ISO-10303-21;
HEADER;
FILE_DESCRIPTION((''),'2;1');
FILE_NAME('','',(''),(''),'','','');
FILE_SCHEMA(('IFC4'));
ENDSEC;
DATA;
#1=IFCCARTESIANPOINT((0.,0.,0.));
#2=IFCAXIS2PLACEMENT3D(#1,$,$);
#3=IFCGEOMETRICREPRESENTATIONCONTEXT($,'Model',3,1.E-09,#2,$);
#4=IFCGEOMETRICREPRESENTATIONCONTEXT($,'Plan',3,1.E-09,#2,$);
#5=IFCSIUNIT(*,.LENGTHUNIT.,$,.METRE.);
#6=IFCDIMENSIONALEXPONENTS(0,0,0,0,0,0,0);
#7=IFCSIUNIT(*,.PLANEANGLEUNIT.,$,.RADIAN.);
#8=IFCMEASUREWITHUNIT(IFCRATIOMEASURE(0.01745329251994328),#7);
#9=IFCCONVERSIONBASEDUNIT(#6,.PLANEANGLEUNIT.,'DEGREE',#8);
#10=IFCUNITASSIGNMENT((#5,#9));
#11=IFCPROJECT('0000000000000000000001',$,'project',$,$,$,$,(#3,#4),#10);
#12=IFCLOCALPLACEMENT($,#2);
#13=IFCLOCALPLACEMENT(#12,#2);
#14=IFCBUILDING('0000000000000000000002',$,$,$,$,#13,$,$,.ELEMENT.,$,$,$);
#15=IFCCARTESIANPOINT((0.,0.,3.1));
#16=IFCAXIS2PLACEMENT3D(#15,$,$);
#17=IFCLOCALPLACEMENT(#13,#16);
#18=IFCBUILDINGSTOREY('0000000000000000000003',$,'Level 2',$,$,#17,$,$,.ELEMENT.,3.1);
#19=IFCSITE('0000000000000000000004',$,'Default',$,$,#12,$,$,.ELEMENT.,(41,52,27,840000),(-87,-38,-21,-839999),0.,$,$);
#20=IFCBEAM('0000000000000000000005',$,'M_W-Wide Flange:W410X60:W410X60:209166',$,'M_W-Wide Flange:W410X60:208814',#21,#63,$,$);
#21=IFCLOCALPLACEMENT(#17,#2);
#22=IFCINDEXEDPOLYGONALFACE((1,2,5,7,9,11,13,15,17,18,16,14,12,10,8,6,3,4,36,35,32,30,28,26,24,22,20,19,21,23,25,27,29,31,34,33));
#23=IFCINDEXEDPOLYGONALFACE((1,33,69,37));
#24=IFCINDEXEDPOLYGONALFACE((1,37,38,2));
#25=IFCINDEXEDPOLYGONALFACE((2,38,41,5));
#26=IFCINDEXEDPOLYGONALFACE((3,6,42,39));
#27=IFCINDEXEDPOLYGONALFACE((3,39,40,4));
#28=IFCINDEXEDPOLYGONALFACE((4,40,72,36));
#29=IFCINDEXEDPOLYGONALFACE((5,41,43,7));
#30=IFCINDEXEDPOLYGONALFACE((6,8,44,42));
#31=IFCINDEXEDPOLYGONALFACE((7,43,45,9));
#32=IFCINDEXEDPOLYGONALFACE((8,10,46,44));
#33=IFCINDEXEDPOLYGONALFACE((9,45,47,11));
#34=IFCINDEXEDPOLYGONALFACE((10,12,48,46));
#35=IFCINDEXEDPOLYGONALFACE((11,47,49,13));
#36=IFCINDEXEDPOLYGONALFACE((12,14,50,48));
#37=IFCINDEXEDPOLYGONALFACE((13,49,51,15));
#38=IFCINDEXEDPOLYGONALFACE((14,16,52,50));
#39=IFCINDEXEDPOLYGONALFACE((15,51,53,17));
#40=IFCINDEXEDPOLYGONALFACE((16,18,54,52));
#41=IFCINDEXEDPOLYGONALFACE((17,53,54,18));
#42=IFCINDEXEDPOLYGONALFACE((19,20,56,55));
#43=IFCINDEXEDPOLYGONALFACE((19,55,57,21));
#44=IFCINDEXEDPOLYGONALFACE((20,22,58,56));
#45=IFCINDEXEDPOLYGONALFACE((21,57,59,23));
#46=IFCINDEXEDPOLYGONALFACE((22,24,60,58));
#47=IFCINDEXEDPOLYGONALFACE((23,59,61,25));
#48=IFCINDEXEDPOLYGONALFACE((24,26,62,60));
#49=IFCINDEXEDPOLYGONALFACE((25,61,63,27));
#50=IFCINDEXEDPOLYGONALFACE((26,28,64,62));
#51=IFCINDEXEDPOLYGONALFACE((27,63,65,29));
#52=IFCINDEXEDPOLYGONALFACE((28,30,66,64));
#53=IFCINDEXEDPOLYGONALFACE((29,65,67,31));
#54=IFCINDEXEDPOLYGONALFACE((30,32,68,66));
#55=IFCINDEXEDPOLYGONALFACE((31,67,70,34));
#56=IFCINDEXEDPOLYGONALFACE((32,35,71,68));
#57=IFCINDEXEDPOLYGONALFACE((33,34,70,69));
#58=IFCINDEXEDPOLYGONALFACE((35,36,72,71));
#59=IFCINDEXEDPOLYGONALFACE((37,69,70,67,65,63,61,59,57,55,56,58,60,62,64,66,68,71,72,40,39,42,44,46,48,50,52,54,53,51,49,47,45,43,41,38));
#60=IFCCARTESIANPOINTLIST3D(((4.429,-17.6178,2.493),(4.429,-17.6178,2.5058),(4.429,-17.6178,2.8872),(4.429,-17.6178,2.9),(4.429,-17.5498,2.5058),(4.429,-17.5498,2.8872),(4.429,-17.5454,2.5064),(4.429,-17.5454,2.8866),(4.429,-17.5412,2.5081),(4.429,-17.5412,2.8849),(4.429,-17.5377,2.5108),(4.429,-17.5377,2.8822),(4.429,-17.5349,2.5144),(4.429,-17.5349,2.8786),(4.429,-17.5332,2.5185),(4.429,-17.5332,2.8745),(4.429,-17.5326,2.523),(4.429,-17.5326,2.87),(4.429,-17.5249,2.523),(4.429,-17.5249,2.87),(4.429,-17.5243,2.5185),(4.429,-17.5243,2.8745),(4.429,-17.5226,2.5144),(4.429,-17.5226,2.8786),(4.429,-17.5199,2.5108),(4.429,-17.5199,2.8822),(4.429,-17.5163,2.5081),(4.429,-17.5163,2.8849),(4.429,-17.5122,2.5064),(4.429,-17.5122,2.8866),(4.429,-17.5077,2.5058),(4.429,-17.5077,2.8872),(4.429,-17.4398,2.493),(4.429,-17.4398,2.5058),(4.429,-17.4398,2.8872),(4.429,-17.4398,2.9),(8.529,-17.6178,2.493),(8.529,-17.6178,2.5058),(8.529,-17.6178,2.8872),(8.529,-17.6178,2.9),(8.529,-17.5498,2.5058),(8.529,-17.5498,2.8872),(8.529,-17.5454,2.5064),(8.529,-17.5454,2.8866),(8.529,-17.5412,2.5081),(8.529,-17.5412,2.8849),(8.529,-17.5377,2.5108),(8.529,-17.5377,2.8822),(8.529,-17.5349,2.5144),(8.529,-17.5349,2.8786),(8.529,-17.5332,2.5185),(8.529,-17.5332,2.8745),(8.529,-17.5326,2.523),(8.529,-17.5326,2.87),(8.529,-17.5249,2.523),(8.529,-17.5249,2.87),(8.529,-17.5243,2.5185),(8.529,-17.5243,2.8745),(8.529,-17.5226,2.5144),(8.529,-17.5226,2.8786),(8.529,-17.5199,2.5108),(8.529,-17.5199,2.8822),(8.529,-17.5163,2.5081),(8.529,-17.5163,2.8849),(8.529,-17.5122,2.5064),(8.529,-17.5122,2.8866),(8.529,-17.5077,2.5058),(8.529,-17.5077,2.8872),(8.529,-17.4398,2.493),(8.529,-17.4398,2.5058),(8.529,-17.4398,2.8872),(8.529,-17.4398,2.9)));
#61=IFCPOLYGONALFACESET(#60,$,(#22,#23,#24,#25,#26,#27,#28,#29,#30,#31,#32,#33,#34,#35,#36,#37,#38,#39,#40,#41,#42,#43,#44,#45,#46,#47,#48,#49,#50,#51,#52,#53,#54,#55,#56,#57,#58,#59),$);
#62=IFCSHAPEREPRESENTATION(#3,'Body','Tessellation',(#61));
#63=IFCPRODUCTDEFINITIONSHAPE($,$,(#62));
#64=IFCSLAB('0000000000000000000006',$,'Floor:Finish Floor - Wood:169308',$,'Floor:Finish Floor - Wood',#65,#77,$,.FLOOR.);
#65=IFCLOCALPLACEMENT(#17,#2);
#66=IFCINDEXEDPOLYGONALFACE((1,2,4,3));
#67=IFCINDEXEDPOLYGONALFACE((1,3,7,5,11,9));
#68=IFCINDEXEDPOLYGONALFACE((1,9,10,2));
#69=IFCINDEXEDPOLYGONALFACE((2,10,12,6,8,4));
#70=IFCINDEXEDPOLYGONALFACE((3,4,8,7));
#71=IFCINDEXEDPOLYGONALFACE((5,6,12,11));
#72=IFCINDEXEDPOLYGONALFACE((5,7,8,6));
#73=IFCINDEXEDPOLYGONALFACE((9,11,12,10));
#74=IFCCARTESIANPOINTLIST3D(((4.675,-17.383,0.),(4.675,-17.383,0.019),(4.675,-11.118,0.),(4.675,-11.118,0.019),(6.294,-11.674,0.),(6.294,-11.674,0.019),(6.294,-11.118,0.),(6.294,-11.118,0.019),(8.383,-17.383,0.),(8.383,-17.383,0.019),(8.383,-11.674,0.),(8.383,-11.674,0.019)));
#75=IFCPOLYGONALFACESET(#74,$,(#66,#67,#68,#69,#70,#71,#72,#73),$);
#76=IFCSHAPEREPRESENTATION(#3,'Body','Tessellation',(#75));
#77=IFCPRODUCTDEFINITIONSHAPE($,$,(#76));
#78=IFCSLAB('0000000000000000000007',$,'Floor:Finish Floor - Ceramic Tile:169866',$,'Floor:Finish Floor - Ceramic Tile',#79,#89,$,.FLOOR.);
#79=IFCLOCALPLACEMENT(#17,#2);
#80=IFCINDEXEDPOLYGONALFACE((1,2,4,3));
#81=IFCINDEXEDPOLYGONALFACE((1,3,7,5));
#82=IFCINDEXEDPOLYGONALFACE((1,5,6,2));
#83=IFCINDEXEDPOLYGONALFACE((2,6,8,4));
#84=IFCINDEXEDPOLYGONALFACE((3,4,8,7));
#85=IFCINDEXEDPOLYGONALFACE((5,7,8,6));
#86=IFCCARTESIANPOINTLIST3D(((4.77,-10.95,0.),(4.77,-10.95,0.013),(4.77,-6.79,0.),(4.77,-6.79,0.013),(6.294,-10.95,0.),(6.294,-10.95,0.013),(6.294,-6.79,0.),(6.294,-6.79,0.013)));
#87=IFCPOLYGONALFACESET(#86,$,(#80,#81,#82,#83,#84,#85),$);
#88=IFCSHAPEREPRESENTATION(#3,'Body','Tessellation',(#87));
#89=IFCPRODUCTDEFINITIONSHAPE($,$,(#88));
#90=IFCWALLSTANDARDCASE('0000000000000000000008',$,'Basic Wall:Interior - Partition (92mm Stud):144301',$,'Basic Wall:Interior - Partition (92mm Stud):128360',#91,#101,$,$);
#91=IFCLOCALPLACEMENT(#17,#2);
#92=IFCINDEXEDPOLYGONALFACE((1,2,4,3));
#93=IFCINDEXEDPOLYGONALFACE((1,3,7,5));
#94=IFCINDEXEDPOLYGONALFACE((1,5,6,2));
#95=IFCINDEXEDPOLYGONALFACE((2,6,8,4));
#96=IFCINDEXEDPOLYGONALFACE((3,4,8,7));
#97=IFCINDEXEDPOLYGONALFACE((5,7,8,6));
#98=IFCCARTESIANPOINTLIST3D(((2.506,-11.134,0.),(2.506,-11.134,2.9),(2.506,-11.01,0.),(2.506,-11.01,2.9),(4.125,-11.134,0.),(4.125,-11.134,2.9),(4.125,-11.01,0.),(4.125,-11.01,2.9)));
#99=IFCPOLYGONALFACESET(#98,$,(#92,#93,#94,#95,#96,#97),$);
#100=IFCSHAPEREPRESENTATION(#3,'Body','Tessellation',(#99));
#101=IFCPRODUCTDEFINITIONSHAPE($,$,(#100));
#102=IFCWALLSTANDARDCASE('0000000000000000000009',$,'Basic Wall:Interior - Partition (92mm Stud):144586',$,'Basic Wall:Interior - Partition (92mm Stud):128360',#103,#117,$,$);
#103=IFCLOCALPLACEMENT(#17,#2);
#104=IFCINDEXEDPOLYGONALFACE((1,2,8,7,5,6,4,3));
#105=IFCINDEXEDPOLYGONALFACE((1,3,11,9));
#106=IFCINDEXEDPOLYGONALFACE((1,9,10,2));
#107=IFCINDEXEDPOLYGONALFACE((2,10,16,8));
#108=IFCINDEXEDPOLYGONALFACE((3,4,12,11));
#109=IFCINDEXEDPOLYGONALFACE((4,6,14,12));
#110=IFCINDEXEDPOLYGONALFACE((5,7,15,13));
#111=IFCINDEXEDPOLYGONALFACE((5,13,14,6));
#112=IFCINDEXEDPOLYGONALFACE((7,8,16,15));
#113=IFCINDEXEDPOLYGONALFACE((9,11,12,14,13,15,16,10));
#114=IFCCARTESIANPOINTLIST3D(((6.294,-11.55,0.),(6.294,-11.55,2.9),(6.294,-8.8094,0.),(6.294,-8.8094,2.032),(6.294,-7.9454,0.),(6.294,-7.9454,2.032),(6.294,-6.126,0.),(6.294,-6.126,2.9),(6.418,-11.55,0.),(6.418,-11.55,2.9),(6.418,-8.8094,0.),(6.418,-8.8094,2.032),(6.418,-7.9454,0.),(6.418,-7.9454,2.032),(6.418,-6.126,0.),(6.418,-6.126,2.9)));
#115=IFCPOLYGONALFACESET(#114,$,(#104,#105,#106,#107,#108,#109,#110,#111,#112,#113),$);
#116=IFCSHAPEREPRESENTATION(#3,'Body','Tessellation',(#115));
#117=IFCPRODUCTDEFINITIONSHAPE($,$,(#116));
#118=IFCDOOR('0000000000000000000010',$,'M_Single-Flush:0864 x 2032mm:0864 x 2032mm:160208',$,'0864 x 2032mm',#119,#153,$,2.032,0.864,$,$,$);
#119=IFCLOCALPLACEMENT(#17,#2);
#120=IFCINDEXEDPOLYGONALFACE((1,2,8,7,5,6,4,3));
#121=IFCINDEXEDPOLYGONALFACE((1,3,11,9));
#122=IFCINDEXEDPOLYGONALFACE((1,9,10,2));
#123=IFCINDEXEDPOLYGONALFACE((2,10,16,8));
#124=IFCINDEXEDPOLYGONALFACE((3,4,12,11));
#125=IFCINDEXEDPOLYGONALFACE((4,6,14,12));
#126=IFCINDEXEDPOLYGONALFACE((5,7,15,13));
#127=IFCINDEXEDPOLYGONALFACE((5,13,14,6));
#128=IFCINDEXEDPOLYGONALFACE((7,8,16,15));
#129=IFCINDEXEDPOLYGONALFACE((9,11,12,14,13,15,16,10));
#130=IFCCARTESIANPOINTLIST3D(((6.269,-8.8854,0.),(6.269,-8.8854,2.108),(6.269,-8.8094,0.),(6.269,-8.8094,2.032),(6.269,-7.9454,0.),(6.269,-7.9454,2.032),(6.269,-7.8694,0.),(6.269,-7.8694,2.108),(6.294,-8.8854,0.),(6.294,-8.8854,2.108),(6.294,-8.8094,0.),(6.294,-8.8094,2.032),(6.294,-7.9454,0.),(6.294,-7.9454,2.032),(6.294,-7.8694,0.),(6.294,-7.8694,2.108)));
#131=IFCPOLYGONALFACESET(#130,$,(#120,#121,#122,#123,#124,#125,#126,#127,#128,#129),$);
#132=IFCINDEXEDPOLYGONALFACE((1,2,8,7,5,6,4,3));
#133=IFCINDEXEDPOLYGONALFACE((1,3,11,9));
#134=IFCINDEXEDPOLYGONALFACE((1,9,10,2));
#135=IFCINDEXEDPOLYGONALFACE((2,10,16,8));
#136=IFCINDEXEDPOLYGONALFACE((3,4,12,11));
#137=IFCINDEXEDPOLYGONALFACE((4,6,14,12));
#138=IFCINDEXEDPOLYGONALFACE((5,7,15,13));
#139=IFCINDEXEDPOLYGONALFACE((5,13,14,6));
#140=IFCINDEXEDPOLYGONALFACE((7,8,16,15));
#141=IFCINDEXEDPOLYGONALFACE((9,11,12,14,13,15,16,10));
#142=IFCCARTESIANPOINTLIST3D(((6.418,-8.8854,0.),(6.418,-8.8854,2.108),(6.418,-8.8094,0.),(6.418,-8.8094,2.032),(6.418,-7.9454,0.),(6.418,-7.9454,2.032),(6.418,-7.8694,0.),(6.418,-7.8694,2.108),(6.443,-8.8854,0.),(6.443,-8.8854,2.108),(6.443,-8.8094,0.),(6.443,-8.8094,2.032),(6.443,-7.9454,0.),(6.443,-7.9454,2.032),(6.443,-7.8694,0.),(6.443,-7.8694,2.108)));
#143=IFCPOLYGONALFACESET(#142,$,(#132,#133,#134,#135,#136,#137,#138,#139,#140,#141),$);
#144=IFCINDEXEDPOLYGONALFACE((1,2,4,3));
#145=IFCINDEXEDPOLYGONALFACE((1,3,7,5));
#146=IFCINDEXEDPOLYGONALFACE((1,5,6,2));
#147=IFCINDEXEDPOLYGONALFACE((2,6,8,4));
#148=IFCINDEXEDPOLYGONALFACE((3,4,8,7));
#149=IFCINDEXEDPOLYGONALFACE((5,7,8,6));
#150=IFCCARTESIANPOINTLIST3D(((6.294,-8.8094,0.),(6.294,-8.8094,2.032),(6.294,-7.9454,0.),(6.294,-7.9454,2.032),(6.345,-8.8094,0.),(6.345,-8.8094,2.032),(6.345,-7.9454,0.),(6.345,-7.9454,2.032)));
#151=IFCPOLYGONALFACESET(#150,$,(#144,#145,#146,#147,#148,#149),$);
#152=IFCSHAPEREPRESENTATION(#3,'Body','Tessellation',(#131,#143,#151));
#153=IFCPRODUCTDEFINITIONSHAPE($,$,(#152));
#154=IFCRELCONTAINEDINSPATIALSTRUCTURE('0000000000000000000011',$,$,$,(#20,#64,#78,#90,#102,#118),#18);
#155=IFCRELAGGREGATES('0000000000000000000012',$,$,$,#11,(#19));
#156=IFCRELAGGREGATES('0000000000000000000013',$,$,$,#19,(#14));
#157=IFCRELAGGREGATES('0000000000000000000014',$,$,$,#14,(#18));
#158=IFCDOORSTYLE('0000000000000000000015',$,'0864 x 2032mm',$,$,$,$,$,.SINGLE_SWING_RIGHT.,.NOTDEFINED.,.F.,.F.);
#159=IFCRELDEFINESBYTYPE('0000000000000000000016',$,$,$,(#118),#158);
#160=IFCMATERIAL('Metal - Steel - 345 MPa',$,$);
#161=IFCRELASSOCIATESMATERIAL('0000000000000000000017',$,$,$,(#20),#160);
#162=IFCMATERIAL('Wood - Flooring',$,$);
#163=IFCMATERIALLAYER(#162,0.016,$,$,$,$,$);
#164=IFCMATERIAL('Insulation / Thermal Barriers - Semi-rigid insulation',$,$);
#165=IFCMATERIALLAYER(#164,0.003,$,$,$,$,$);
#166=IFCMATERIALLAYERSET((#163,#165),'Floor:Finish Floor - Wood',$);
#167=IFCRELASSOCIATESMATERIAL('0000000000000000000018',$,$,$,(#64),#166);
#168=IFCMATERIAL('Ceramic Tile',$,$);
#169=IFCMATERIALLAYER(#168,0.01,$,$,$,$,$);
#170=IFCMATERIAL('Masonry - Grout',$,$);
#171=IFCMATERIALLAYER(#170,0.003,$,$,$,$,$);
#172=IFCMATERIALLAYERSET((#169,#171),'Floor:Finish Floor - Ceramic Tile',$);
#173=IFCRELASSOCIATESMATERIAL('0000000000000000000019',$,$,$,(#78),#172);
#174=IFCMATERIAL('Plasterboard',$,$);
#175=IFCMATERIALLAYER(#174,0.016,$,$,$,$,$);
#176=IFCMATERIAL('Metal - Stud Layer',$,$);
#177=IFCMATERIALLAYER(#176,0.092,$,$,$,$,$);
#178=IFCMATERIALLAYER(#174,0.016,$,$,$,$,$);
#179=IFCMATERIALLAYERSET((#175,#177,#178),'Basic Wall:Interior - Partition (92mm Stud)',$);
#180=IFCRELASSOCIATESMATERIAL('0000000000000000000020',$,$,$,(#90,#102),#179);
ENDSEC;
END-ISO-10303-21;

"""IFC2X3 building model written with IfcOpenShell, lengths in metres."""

from ifc_helpers import new_model, entity, si_unit, converted_unit, frame, frame_2d, origin, origin_2d_with_axis, place, context, project, spatial, polyline, circle_curve, parameter, trimmed, segment, composite_curve, rectangle, outline, extrude, source, transform, mapped, material, layer, layer_set, layer_usage, type_object, type_shapes, element, fill, save


model = new_model("IFC2X3")

# Units and contexts
model_context = context("Model", 3, precision=1e-09, world=origin())
plan_context = context("Plan", 3, precision=1e-09, world=origin())
ifc_project = project(units=[si_unit("LENGTHUNIT", "METRE"), converted_unit("PLANEANGLEUNIT", "DEGREE", entity("IfcRatioMeasure", 0.01745329251994328), si_unit("PLANEANGLEUNIT", "RADIAN"), dimensions=[0, 0, 0, 0, 0, 0, 0])], contexts=[model_context, plan_context])

# Site, building, storey
site_placement = place(None, origin())
site = spatial("IfcSite", under=ifc_project, at=site_placement, Name="Default", CompositionType="ELEMENT", RefLatitude=(41, 52, 27, 840000), RefLongitude=(-87, -38, -21, -839999), RefElevation=0.0)
building_placement = place(site_placement, origin())
building = spatial("IfcBuilding", under=site, at=building_placement, CompositionType="ELEMENT")
storey_placement = place(building_placement, frame((0.0, 0.0, 3.1)))
storey = spatial("IfcBuildingStorey", under=building, at=storey_placement, Name="Level 2", CompositionType="ELEMENT", Elevation=3.1)

# Beam
ifc_material_1 = material(Name="Metal - Steel - 345 MPa")
beam_placement = place(storey_placement, frame((4.429, -17.5288, 2.9), z_axis=(0.0, 0.0, 1.0), x_axis=(0.0, -1.0, 0.0)))
element("IfcBeam", 1, at=beam_placement, inside=storey, material=ifc_material_1, Name="M_W-Wide Flange:W410X60:W410X60:209166", ObjectType="M_W-Wide Flange:W410X60:208814", context=model_context, shape_type="SweptSolid", body=[
    extrude(outline(composite_curve([segment(polyline([(-0.089, -0.1907), (-0.089, -0.2035)]), True, "CONTINUOUS"), segment(polyline([(-0.089, -0.2035), (0.089, -0.2035)]), True, "CONTINUOUS"), segment(polyline([(0.089, -0.2035), (0.089, -0.1907)]), True, "CONTINUOUS"), segment(polyline([(0.089, -0.1907), (0.021, -0.1907)]), True, "CONTINUOUS"), segment(trimmed(circle_curve(frame_2d((0.021, -0.1735), x_axis=(0.0, -1.0)), 0.0172), [parameter(270.0)], [parameter(360.0)], True, "PARAMETER"), False, "CONTINUOUS"), segment(polyline([(0.0038, -0.1735), (0.0038, 0.1735)]), True, "CONTINUOUS"), segment(trimmed(circle_curve(frame_2d((0.021, 0.1735), x_axis=(-1.0, 0.0)), 0.0172), [parameter(270.0)], [parameter(360.0)], True, "PARAMETER"), False, "CONTINUOUS"), segment(polyline([(0.021, 0.1907), (0.089, 0.1907)]), True, "CONTINUOUS"), segment(polyline([(0.089, 0.1907), (0.089, 0.2035)]), True, "CONTINUOUS"), segment(polyline([(0.089, 0.2035), (-0.089, 0.2035)]), True, "CONTINUOUS"), segment(polyline([(-0.089, 0.2035), (-0.089, 0.1907)]), True, "CONTINUOUS"), segment(polyline([(-0.089, 0.1907), (-0.0211, 0.1907)]), True, "CONTINUOUS"), segment(trimmed(circle_curve(frame_2d((-0.0211, 0.1735), x_axis=(0.0, 1.0)), 0.0172), [parameter(270.0)], [parameter(0.0)], True, "PARAMETER"), False, "CONTINUOUS"), segment(polyline([(-0.0039, 0.1735), (-0.0039, -0.1735)]), True, "CONTINUOUS"), segment(trimmed(circle_curve(frame_2d((-0.0211, -0.1735), x_axis=(1.0, 0.0)), 0.0172), [parameter(270.0)], [parameter(0.0)], True, "PARAMETER"), False, "CONTINUOUS"), segment(polyline([(-0.0211, -0.1907), (-0.089, -0.1907)]), True, "CONTINUOUS")], self_intersect=False)), frame((0.0, 0.0, -0.2035), z_axis=(0.0, -1.0, 0.0), x_axis=(1.0, 0.0, 0.0)), (0.0, 0.0, -1.0), 4.1),
])

# Slabs
ifc_material_2 = material(Name="Wood - Flooring")
ifc_layer_1 = layer(ifc_material_2, 0.016)
ifc_material_3 = material(Name="Insulation / Thermal Barriers - Semi-rigid insulation")
ifc_layer_2 = layer(ifc_material_3, 0.003)
ifc_layer_set_1 = layer_set([ifc_layer_1, ifc_layer_2], Name="Floor:Finish Floor - Wood")
ifc_layer_usage_1 = layer_usage(ifc_layer_set_1, "AXIS3", "POSITIVE", 0.0)
slab_1_placement = place(storey_placement, frame((4.675, -17.383, 0.0)))
element("IfcSlab", 2, at=slab_1_placement, inside=storey, material=ifc_layer_usage_1, Name="Floor:Finish Floor - Wood:169308", ObjectType="Floor:Finish Floor - Wood", PredefinedType="FLOOR", context=model_context, shape_type="SweptSolid", body=[
    extrude(outline(polyline([(-1.854, 2.5765), (-1.854, -3.1325), (1.854, -3.1325), (1.854, 3.1325), (0.235, 3.1325), (0.235, 2.5765), (-1.854, 2.5765)])), frame((1.854, 3.1325, 0.019), z_axis=(0.0, 0.0, -1.0), x_axis=(-1.0, 0.0, 0.0)), (0.0, 0.0, 1.0), 0.019),
])
ifc_material_4 = material(Name="Ceramic Tile")
ifc_layer_3 = layer(ifc_material_4, 0.01)
ifc_material_5 = material(Name="Masonry - Grout")
ifc_layer_4 = layer(ifc_material_5, 0.003)
ifc_layer_set_2 = layer_set([ifc_layer_3, ifc_layer_4], Name="Floor:Finish Floor - Ceramic Tile")
ifc_layer_usage_2 = layer_usage(ifc_layer_set_2, "AXIS3", "POSITIVE", 0.0)
slab_2_placement = place(storey_placement, frame((4.77, -10.95, 0.0)))
element("IfcSlab", 3, at=slab_2_placement, inside=storey, material=ifc_layer_usage_2, Name="Floor:Finish Floor - Ceramic Tile:169866", ObjectType="Floor:Finish Floor - Ceramic Tile", PredefinedType="FLOOR", context=model_context, shape_type="SweptSolid", body=[
    extrude(rectangle(XDim=4.16, YDim=1.524, at=frame_2d((0.0, 0.0), x_axis=(0.0, -1.0))), frame((0.762, 2.08, 0.013), z_axis=(0.0, 0.0, -1.0), x_axis=(-1.0, 0.0, 0.0)), (0.0, 0.0, 1.0), 0.013),
])

# Shared definitions
ifc_material_6 = material(Name="Metal - Stud Layer")
ifc_material_7 = material(Name="Plasterboard")

# Wall
ifc_layer_5 = layer(ifc_material_7, 0.016)
ifc_layer_6 = layer(ifc_material_6, 0.092)
ifc_layer_7 = layer(ifc_material_7, 0.016)
ifc_layer_set_3 = layer_set([ifc_layer_5, ifc_layer_6, ifc_layer_7], Name="Basic Wall:Interior - Partition (92mm Stud)")
ifc_layer_usage_3 = layer_usage(ifc_layer_set_3, "AXIS2", "NEGATIVE", 0.062)
wall_1_placement = place(storey_placement, frame((4.125, -11.072, 0.0), z_axis=(0.0, 0.0, 1.0), x_axis=(-1.0, 0.0, 0.0)))
element("IfcWallStandardCase", 4, at=wall_1_placement, inside=storey, material=ifc_layer_usage_3, Name="Basic Wall:Interior - Partition (92mm Stud):144301", ObjectType="Basic Wall:Interior - Partition (92mm Stud):128360", context=model_context, shape_type="SweptSolid", body=[
    extrude(rectangle(XDim=1.619, YDim=0.124, at=frame_2d((0.8095, 0.0), x_axis=(-1.0, 0.0))), origin(), (0.0, 0.0, 1.0), 2.9),
])

# Wall, opening, door
ifc_layer_usage_4 = layer_usage(ifc_layer_set_3, "AXIS2", "NEGATIVE", 0.062)
wall_2_placement = place(storey_placement, frame((6.356, -11.55, 0.0), z_axis=(0.0, 0.0, 1.0), x_axis=(0.0, 1.0, 0.0)))
wall_2 = element("IfcWallStandardCase", 5, at=wall_2_placement, inside=storey, material=ifc_layer_usage_4, Name="Basic Wall:Interior - Partition (92mm Stud):144586", ObjectType="Basic Wall:Interior - Partition (92mm Stud):128360", context=model_context, shape_type="SweptSolid", body=[
    extrude(rectangle(XDim=5.424, YDim=0.124, at=frame_2d((2.712, 0.0), x_axis=(-1.0, 0.0))), origin(), (0.0, 0.0, 1.0), 2.9),
])
opening_1_placement = place(wall_2_placement, frame((2.7406, -0.062, 0.0)))
opening_1 = element("IfcOpeningElement", 6, at=opening_1_placement, cuts=wall_2, ObjectType="Opening", context=model_context, shape_type="SweptSolid", body=[
    extrude(rectangle(XDim=0.864, YDim=2.032, at=frame_2d((1.016, 0.432), x_axis=(0.0, 1.0))), frame((0.0, 0.0, 0.0), z_axis=(0.0, 1.0, 0.0), x_axis=(0.0, 0.0, 1.0)), (0.0, 0.0, 1.0), 0.124),
])
door_style = type_object("IfcDoorStyle", Name="0864 x 2032mm", ConstructionType="NOTDEFINED", OperationType="SINGLE_SWING_RIGHT", ParameterTakesPrecedence=False, Sizeable=False)
shared_shape_1 = source(origin(), model_context, "Body", "SweptSolid", [
    extrude(outline(polyline([(-0.508, -1.073), (0.508, -1.073), (0.508, 1.035), (0.432, 1.035), (0.432, -0.997), (-0.432, -0.997), (-0.432, 1.035), (-0.508, 1.035), (-0.508, -1.073)])), frame((0.432, 0.124, 1.035), z_axis=(0.0, 1.0, 0.0), x_axis=(1.0, 0.0, 0.0)), (0.0, 0.0, 1.0), 0.025),
    extrude(outline(polyline([(-1.073, -0.508), (1.035, -0.508), (1.035, -0.432), (-0.997, -0.432), (-0.997, 0.432), (1.035, 0.432), (1.035, 0.508), (-1.073, 0.508), (-1.073, -0.508)])), frame((0.432, -0.025, 1.035), z_axis=(0.0, 1.0, 0.0), x_axis=(0.0, 0.0, -1.0)), (0.0, 0.0, 1.0), 0.025),
    extrude(rectangle(XDim=0.051, YDim=0.864, at=origin_2d_with_axis()), frame((0.432, 0.0985, 0.0), z_axis=(0.0, 0.0, 1.0), x_axis=(0.0, 1.0, 0.0)), (0.0, 0.0, 1.0), 2.032),
])
type_shapes(door_style, [shared_shape_1])
door_placement = place(opening_1_placement, origin())
door = element("IfcDoor", 7, at=door_placement, inside=storey, type_object=door_style, Name="M_Single-Flush:0864 x 2032mm:0864 x 2032mm:160208", ObjectType="0864 x 2032mm", OverallHeight=2.032, OverallWidth=0.864, context=model_context, shape_type="MappedRepresentation", body=[
    mapped(shared_shape_1, transform((0.0, 0.0, 0.0), scale=1.0)),
])
fill(opening_1, door)

save(model, "model.ifc")
